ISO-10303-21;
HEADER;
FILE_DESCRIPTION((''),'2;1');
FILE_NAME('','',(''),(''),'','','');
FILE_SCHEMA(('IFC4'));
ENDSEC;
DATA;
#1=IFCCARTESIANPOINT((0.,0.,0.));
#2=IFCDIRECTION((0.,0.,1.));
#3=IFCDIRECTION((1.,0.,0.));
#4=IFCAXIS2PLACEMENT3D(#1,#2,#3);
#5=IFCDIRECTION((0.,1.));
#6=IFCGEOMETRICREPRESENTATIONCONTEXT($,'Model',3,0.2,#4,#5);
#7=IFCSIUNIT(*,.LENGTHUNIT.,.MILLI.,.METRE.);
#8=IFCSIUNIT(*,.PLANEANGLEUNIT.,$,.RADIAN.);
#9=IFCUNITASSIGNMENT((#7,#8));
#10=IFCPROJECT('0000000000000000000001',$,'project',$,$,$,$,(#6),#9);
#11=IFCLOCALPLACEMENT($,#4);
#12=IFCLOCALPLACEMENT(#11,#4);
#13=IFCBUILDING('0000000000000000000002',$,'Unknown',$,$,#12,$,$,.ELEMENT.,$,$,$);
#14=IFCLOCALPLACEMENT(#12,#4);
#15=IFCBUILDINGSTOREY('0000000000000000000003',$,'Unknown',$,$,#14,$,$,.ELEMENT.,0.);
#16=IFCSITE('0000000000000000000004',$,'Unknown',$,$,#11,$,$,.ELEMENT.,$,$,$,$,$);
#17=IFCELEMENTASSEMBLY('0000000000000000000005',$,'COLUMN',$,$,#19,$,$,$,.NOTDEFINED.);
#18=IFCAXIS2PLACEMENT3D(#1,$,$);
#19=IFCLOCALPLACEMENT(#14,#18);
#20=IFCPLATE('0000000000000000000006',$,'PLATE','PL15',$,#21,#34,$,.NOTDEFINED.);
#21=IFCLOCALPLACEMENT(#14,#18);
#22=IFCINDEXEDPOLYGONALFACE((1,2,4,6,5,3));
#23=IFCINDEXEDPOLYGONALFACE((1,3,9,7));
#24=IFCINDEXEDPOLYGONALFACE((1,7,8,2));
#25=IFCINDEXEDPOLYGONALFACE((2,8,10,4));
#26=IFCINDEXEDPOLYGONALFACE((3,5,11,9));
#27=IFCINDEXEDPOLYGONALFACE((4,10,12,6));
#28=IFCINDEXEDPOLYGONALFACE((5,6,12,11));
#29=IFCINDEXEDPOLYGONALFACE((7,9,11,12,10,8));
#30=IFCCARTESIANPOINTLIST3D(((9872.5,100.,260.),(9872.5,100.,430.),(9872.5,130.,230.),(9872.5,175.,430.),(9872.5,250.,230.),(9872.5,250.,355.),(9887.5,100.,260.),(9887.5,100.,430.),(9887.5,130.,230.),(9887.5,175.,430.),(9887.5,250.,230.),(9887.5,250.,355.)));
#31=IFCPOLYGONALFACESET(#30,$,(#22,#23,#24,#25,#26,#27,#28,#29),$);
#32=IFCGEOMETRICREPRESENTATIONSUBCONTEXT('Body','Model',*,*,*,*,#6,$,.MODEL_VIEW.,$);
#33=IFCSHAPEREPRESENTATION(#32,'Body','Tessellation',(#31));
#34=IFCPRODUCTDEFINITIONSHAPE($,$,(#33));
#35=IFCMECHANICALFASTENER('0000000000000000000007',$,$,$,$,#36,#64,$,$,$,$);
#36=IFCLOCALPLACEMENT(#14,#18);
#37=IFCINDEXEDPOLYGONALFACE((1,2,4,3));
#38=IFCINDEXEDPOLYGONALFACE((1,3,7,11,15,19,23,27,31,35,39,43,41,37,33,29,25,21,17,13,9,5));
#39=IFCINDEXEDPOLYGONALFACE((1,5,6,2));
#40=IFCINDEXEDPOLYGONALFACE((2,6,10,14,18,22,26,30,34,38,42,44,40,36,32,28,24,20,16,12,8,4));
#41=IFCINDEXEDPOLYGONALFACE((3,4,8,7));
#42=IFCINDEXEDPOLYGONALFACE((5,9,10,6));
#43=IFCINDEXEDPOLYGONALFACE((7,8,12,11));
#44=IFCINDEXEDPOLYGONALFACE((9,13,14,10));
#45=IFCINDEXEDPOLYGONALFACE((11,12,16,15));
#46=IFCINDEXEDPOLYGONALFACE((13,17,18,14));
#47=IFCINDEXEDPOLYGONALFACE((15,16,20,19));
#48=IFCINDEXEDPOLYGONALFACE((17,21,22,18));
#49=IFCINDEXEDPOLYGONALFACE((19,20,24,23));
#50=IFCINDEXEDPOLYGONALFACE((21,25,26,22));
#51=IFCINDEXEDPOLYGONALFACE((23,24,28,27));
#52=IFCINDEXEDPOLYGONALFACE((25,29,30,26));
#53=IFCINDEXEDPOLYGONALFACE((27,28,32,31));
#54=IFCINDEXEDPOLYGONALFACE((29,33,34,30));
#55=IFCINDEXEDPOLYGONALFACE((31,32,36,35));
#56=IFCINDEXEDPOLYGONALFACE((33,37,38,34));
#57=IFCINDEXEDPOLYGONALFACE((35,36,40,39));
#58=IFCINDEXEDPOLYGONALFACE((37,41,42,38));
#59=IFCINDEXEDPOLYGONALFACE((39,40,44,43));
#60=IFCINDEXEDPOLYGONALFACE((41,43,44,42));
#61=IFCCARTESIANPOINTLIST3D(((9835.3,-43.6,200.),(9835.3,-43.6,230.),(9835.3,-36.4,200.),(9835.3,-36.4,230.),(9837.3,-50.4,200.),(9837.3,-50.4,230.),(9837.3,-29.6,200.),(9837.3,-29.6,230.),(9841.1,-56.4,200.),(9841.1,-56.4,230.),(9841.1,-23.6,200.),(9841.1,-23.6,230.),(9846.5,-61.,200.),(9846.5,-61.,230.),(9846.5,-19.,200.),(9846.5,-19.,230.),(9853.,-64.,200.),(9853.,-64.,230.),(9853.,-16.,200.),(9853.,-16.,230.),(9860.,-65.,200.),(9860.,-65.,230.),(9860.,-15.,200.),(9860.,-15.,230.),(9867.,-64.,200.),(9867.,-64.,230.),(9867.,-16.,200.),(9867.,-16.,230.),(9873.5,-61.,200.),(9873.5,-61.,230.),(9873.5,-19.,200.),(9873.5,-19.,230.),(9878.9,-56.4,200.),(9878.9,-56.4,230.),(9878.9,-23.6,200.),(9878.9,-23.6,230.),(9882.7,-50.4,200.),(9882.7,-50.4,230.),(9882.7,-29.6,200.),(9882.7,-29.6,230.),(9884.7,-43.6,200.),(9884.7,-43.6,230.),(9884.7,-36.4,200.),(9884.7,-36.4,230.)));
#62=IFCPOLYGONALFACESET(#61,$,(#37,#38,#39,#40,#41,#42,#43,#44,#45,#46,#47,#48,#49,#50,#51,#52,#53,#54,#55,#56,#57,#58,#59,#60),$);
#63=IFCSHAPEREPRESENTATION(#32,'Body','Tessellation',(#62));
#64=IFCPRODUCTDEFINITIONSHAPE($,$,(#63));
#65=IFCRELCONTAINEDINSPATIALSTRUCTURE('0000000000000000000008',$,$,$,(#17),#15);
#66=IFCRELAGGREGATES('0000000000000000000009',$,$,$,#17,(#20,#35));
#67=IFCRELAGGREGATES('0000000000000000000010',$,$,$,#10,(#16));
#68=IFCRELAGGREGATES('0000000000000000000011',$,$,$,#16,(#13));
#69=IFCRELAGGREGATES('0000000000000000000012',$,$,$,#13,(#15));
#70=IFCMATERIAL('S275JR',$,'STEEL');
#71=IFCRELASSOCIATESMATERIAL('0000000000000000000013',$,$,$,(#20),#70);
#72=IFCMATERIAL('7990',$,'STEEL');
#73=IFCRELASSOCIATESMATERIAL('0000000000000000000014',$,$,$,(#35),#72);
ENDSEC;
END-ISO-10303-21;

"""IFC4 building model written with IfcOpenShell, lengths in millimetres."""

from ifc_helpers import new_model, si_unit, direction, frame, origin_with_axes, place, context, subcontext, project, spatial, line, arc, indexed_curve, outline, extrude, source, transform, mapped, material, element, aggregate, save


model = new_model("IFC4")

# Units and contexts
model_context = context("Model", 3, precision=0.2, world=origin_with_axes(), true_north=direction((0.0, 1.0)))
body_context = subcontext(model_context, "Body", "Model", "MODEL_VIEW")
ifc_project = project(units=[si_unit("LENGTHUNIT", "METRE", prefix="MILLI"), si_unit("PLANEANGLEUNIT", "RADIAN")], contexts=[model_context])

# Site, building, storey
site_placement = place(None, origin_with_axes())
site = spatial("IfcSite", under=ifc_project, at=site_placement, Name="Unknown", CompositionType="ELEMENT")
building_placement = place(site_placement, origin_with_axes())
building = spatial("IfcBuilding", under=site, at=building_placement, Name="Unknown", CompositionType="ELEMENT")
storey_placement = place(building_placement, origin_with_axes())
storey = spatial("IfcBuildingStorey", under=building, at=storey_placement, Name="Unknown", CompositionType="ELEMENT", Elevation=0.0)

# Shared definitions
ifc_material_1 = material(Name="S275JR", Category="STEEL")

# Element assembly, plate, mechanical fastener
assembly_1_placement = place(storey_placement, frame((9800.0, 0.0, 200.0), z_axis=(-1.0, 0.0, 0.0), x_axis=(0.0, 0.0, 1.0)))
assembly_1 = element("IfcElementAssembly", 1, at=assembly_1_placement, inside=storey, Name="COLUMN", PredefinedType="NOTDEFINED")
plate_1_placement = place(assembly_1_placement, frame((60.0, 100.0, -80.0), z_axis=(0.0, -0.000002, -1.0), x_axis=(-0.707113, 0.707101, 0.0)))
plate_1 = element("IfcPlate", 2, at=plate_1_placement, material=ifc_material_1, Name="PLATE", Description="PL15", PredefinedType="NOTDEFINED", context=body_context, shape_type="SolidModel", body=[
    extrude(outline(indexed_curve([(0.0, 0.0), (42.4, 0.0), (127.3, 84.9), (38.9, 173.2), (-67.2, 173.2), (-120.2, 120.2)], segments=[line(1, 2, 3, 4, 5, 6, 1)])), frame((0.0, 0.0, 7.5), z_axis=(0.0, 0.0, 1.0), x_axis=(1.0, 0.0, 0.0)), (0.0, -0.000002, -1.0), 15.0),
])
ifc_material_2 = material(Name="7990", Category="STEEL")
shared_shape_1 = source(origin_with_axes(), body_context, "Body", "SweptSolid", [
    extrude(outline(indexed_curve([(25.0, 0.0), (0.0, 25.0), (-25.0, 0.0), (0.0, -25.0)], segments=[arc(1, 2, 3), arc(3, 4, 1)])), frame((0.0, 0.0, 0.0), z_axis=(0.0, -0.000002, -1.0), x_axis=(0.0, 1.0, 0.0)), (0.0, 0.0, 1.0), 30.0),
])
mechanical_fastener_1_placement = place(assembly_1_placement, frame((30.0, -40.0, -60.0), z_axis=(1.0, 0.0, 0.0), x_axis=(0.0, -0.000002, -1.0)))
mechanical_fastener_1 = element("IfcMechanicalFastener", 3, at=mechanical_fastener_1_placement, material=ifc_material_2, context=body_context, shape_type="MappedRepresentation", body=[
    mapped(shared_shape_1, transform((0.0, 0.0, 0.0))),
])

aggregate(assembly_1, [plate_1, mechanical_fastener_1])

save(model, "model.ifc")
